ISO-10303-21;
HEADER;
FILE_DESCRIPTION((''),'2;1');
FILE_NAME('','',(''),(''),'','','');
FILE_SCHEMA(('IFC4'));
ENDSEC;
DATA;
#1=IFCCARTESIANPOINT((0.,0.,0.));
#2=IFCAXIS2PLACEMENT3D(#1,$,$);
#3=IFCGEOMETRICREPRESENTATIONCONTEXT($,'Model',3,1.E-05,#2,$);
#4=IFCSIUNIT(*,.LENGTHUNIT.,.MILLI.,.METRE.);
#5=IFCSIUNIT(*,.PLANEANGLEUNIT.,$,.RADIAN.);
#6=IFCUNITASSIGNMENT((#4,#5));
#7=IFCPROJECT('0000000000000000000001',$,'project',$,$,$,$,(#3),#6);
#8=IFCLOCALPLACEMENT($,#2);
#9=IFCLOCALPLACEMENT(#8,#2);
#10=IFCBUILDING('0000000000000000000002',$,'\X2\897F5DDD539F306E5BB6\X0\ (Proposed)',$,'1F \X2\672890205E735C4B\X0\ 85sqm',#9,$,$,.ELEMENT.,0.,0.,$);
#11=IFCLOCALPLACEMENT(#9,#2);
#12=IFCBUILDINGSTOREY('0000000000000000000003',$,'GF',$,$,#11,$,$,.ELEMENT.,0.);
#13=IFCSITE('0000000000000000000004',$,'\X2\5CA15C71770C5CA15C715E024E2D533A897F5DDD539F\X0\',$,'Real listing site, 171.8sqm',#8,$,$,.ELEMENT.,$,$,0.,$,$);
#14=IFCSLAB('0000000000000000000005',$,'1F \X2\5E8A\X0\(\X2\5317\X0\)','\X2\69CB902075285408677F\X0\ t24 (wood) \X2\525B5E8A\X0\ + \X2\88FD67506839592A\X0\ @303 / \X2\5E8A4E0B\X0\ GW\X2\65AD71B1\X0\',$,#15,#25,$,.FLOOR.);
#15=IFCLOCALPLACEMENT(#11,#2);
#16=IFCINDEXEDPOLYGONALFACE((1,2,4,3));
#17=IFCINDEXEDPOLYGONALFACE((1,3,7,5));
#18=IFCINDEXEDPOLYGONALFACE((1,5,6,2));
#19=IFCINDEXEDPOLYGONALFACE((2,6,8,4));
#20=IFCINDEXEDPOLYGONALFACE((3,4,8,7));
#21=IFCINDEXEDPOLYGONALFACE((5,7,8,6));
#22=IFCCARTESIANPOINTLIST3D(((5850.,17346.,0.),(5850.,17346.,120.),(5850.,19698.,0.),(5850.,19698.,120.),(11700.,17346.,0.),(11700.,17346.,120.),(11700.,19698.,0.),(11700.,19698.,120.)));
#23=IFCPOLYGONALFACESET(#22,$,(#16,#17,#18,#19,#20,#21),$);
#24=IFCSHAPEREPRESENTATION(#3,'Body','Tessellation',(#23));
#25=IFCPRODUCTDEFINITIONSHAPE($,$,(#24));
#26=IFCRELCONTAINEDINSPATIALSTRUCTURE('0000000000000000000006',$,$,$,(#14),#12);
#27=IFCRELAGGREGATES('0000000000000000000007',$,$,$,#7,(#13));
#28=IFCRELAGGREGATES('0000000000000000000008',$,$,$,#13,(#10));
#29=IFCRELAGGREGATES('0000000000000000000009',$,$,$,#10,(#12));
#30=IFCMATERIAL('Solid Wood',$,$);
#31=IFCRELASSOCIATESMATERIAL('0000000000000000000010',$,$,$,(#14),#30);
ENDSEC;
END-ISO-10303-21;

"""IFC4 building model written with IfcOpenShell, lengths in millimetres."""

from ifc_helpers import new_model, si_unit, frame, frame_2d, origin, place, context, project, spatial, rectangle, extrude, material, element, save


model = new_model("IFC4")

# Units and contexts
model_context = context("Model", 3, precision=1e-05, world=origin())
ifc_project = project(units=[si_unit("LENGTHUNIT", "METRE", prefix="MILLI"), si_unit("PLANEANGLEUNIT", "RADIAN")], contexts=[model_context])

# Site, building, storey
site_placement = place(None, origin())
site = spatial("IfcSite", under=ifc_project, at=site_placement, Name="岡山県岡山市中区西川原", ObjectType="Real listing site, 171.8sqm", CompositionType="ELEMENT", RefElevation=0.0)
building_placement = place(site_placement, origin())
building = spatial("IfcBuilding", under=site, at=building_placement, Name="西川原の家 (Proposed)", ObjectType="1F 木造平屋 85sqm", CompositionType="ELEMENT", ElevationOfRefHeight=0.0, ElevationOfTerrain=0.0)
storey_placement = place(building_placement, origin())
storey = spatial("IfcBuildingStorey", under=building, at=storey_placement, Name="GF", CompositionType="ELEMENT", Elevation=0.0)

# Slab
ifc_material_1 = material(Name="Solid Wood")
slab_1_placement = place(storey_placement, frame((2925.0, 8673.0, 0.0)))
element("IfcSlab", 1, at=slab_1_placement, inside=storey, material=ifc_material_1, Name="1F 床(北)", Description="構造用合板 t24 (wood) 剛床 + 製材根太 @303 / 床下 GW断熱", PredefinedType="FLOOR", context=model_context, shape_type="SweptSolid", body=[
    extrude(rectangle(XDim=5850.0, YDim=2352.0, at=frame_2d((2925.0, 1176.0))), frame((2925.0, 8673.0, 0.0)), (0.0, 0.0, 1.0), 120.0),
])

save(model, "model.ifc")
